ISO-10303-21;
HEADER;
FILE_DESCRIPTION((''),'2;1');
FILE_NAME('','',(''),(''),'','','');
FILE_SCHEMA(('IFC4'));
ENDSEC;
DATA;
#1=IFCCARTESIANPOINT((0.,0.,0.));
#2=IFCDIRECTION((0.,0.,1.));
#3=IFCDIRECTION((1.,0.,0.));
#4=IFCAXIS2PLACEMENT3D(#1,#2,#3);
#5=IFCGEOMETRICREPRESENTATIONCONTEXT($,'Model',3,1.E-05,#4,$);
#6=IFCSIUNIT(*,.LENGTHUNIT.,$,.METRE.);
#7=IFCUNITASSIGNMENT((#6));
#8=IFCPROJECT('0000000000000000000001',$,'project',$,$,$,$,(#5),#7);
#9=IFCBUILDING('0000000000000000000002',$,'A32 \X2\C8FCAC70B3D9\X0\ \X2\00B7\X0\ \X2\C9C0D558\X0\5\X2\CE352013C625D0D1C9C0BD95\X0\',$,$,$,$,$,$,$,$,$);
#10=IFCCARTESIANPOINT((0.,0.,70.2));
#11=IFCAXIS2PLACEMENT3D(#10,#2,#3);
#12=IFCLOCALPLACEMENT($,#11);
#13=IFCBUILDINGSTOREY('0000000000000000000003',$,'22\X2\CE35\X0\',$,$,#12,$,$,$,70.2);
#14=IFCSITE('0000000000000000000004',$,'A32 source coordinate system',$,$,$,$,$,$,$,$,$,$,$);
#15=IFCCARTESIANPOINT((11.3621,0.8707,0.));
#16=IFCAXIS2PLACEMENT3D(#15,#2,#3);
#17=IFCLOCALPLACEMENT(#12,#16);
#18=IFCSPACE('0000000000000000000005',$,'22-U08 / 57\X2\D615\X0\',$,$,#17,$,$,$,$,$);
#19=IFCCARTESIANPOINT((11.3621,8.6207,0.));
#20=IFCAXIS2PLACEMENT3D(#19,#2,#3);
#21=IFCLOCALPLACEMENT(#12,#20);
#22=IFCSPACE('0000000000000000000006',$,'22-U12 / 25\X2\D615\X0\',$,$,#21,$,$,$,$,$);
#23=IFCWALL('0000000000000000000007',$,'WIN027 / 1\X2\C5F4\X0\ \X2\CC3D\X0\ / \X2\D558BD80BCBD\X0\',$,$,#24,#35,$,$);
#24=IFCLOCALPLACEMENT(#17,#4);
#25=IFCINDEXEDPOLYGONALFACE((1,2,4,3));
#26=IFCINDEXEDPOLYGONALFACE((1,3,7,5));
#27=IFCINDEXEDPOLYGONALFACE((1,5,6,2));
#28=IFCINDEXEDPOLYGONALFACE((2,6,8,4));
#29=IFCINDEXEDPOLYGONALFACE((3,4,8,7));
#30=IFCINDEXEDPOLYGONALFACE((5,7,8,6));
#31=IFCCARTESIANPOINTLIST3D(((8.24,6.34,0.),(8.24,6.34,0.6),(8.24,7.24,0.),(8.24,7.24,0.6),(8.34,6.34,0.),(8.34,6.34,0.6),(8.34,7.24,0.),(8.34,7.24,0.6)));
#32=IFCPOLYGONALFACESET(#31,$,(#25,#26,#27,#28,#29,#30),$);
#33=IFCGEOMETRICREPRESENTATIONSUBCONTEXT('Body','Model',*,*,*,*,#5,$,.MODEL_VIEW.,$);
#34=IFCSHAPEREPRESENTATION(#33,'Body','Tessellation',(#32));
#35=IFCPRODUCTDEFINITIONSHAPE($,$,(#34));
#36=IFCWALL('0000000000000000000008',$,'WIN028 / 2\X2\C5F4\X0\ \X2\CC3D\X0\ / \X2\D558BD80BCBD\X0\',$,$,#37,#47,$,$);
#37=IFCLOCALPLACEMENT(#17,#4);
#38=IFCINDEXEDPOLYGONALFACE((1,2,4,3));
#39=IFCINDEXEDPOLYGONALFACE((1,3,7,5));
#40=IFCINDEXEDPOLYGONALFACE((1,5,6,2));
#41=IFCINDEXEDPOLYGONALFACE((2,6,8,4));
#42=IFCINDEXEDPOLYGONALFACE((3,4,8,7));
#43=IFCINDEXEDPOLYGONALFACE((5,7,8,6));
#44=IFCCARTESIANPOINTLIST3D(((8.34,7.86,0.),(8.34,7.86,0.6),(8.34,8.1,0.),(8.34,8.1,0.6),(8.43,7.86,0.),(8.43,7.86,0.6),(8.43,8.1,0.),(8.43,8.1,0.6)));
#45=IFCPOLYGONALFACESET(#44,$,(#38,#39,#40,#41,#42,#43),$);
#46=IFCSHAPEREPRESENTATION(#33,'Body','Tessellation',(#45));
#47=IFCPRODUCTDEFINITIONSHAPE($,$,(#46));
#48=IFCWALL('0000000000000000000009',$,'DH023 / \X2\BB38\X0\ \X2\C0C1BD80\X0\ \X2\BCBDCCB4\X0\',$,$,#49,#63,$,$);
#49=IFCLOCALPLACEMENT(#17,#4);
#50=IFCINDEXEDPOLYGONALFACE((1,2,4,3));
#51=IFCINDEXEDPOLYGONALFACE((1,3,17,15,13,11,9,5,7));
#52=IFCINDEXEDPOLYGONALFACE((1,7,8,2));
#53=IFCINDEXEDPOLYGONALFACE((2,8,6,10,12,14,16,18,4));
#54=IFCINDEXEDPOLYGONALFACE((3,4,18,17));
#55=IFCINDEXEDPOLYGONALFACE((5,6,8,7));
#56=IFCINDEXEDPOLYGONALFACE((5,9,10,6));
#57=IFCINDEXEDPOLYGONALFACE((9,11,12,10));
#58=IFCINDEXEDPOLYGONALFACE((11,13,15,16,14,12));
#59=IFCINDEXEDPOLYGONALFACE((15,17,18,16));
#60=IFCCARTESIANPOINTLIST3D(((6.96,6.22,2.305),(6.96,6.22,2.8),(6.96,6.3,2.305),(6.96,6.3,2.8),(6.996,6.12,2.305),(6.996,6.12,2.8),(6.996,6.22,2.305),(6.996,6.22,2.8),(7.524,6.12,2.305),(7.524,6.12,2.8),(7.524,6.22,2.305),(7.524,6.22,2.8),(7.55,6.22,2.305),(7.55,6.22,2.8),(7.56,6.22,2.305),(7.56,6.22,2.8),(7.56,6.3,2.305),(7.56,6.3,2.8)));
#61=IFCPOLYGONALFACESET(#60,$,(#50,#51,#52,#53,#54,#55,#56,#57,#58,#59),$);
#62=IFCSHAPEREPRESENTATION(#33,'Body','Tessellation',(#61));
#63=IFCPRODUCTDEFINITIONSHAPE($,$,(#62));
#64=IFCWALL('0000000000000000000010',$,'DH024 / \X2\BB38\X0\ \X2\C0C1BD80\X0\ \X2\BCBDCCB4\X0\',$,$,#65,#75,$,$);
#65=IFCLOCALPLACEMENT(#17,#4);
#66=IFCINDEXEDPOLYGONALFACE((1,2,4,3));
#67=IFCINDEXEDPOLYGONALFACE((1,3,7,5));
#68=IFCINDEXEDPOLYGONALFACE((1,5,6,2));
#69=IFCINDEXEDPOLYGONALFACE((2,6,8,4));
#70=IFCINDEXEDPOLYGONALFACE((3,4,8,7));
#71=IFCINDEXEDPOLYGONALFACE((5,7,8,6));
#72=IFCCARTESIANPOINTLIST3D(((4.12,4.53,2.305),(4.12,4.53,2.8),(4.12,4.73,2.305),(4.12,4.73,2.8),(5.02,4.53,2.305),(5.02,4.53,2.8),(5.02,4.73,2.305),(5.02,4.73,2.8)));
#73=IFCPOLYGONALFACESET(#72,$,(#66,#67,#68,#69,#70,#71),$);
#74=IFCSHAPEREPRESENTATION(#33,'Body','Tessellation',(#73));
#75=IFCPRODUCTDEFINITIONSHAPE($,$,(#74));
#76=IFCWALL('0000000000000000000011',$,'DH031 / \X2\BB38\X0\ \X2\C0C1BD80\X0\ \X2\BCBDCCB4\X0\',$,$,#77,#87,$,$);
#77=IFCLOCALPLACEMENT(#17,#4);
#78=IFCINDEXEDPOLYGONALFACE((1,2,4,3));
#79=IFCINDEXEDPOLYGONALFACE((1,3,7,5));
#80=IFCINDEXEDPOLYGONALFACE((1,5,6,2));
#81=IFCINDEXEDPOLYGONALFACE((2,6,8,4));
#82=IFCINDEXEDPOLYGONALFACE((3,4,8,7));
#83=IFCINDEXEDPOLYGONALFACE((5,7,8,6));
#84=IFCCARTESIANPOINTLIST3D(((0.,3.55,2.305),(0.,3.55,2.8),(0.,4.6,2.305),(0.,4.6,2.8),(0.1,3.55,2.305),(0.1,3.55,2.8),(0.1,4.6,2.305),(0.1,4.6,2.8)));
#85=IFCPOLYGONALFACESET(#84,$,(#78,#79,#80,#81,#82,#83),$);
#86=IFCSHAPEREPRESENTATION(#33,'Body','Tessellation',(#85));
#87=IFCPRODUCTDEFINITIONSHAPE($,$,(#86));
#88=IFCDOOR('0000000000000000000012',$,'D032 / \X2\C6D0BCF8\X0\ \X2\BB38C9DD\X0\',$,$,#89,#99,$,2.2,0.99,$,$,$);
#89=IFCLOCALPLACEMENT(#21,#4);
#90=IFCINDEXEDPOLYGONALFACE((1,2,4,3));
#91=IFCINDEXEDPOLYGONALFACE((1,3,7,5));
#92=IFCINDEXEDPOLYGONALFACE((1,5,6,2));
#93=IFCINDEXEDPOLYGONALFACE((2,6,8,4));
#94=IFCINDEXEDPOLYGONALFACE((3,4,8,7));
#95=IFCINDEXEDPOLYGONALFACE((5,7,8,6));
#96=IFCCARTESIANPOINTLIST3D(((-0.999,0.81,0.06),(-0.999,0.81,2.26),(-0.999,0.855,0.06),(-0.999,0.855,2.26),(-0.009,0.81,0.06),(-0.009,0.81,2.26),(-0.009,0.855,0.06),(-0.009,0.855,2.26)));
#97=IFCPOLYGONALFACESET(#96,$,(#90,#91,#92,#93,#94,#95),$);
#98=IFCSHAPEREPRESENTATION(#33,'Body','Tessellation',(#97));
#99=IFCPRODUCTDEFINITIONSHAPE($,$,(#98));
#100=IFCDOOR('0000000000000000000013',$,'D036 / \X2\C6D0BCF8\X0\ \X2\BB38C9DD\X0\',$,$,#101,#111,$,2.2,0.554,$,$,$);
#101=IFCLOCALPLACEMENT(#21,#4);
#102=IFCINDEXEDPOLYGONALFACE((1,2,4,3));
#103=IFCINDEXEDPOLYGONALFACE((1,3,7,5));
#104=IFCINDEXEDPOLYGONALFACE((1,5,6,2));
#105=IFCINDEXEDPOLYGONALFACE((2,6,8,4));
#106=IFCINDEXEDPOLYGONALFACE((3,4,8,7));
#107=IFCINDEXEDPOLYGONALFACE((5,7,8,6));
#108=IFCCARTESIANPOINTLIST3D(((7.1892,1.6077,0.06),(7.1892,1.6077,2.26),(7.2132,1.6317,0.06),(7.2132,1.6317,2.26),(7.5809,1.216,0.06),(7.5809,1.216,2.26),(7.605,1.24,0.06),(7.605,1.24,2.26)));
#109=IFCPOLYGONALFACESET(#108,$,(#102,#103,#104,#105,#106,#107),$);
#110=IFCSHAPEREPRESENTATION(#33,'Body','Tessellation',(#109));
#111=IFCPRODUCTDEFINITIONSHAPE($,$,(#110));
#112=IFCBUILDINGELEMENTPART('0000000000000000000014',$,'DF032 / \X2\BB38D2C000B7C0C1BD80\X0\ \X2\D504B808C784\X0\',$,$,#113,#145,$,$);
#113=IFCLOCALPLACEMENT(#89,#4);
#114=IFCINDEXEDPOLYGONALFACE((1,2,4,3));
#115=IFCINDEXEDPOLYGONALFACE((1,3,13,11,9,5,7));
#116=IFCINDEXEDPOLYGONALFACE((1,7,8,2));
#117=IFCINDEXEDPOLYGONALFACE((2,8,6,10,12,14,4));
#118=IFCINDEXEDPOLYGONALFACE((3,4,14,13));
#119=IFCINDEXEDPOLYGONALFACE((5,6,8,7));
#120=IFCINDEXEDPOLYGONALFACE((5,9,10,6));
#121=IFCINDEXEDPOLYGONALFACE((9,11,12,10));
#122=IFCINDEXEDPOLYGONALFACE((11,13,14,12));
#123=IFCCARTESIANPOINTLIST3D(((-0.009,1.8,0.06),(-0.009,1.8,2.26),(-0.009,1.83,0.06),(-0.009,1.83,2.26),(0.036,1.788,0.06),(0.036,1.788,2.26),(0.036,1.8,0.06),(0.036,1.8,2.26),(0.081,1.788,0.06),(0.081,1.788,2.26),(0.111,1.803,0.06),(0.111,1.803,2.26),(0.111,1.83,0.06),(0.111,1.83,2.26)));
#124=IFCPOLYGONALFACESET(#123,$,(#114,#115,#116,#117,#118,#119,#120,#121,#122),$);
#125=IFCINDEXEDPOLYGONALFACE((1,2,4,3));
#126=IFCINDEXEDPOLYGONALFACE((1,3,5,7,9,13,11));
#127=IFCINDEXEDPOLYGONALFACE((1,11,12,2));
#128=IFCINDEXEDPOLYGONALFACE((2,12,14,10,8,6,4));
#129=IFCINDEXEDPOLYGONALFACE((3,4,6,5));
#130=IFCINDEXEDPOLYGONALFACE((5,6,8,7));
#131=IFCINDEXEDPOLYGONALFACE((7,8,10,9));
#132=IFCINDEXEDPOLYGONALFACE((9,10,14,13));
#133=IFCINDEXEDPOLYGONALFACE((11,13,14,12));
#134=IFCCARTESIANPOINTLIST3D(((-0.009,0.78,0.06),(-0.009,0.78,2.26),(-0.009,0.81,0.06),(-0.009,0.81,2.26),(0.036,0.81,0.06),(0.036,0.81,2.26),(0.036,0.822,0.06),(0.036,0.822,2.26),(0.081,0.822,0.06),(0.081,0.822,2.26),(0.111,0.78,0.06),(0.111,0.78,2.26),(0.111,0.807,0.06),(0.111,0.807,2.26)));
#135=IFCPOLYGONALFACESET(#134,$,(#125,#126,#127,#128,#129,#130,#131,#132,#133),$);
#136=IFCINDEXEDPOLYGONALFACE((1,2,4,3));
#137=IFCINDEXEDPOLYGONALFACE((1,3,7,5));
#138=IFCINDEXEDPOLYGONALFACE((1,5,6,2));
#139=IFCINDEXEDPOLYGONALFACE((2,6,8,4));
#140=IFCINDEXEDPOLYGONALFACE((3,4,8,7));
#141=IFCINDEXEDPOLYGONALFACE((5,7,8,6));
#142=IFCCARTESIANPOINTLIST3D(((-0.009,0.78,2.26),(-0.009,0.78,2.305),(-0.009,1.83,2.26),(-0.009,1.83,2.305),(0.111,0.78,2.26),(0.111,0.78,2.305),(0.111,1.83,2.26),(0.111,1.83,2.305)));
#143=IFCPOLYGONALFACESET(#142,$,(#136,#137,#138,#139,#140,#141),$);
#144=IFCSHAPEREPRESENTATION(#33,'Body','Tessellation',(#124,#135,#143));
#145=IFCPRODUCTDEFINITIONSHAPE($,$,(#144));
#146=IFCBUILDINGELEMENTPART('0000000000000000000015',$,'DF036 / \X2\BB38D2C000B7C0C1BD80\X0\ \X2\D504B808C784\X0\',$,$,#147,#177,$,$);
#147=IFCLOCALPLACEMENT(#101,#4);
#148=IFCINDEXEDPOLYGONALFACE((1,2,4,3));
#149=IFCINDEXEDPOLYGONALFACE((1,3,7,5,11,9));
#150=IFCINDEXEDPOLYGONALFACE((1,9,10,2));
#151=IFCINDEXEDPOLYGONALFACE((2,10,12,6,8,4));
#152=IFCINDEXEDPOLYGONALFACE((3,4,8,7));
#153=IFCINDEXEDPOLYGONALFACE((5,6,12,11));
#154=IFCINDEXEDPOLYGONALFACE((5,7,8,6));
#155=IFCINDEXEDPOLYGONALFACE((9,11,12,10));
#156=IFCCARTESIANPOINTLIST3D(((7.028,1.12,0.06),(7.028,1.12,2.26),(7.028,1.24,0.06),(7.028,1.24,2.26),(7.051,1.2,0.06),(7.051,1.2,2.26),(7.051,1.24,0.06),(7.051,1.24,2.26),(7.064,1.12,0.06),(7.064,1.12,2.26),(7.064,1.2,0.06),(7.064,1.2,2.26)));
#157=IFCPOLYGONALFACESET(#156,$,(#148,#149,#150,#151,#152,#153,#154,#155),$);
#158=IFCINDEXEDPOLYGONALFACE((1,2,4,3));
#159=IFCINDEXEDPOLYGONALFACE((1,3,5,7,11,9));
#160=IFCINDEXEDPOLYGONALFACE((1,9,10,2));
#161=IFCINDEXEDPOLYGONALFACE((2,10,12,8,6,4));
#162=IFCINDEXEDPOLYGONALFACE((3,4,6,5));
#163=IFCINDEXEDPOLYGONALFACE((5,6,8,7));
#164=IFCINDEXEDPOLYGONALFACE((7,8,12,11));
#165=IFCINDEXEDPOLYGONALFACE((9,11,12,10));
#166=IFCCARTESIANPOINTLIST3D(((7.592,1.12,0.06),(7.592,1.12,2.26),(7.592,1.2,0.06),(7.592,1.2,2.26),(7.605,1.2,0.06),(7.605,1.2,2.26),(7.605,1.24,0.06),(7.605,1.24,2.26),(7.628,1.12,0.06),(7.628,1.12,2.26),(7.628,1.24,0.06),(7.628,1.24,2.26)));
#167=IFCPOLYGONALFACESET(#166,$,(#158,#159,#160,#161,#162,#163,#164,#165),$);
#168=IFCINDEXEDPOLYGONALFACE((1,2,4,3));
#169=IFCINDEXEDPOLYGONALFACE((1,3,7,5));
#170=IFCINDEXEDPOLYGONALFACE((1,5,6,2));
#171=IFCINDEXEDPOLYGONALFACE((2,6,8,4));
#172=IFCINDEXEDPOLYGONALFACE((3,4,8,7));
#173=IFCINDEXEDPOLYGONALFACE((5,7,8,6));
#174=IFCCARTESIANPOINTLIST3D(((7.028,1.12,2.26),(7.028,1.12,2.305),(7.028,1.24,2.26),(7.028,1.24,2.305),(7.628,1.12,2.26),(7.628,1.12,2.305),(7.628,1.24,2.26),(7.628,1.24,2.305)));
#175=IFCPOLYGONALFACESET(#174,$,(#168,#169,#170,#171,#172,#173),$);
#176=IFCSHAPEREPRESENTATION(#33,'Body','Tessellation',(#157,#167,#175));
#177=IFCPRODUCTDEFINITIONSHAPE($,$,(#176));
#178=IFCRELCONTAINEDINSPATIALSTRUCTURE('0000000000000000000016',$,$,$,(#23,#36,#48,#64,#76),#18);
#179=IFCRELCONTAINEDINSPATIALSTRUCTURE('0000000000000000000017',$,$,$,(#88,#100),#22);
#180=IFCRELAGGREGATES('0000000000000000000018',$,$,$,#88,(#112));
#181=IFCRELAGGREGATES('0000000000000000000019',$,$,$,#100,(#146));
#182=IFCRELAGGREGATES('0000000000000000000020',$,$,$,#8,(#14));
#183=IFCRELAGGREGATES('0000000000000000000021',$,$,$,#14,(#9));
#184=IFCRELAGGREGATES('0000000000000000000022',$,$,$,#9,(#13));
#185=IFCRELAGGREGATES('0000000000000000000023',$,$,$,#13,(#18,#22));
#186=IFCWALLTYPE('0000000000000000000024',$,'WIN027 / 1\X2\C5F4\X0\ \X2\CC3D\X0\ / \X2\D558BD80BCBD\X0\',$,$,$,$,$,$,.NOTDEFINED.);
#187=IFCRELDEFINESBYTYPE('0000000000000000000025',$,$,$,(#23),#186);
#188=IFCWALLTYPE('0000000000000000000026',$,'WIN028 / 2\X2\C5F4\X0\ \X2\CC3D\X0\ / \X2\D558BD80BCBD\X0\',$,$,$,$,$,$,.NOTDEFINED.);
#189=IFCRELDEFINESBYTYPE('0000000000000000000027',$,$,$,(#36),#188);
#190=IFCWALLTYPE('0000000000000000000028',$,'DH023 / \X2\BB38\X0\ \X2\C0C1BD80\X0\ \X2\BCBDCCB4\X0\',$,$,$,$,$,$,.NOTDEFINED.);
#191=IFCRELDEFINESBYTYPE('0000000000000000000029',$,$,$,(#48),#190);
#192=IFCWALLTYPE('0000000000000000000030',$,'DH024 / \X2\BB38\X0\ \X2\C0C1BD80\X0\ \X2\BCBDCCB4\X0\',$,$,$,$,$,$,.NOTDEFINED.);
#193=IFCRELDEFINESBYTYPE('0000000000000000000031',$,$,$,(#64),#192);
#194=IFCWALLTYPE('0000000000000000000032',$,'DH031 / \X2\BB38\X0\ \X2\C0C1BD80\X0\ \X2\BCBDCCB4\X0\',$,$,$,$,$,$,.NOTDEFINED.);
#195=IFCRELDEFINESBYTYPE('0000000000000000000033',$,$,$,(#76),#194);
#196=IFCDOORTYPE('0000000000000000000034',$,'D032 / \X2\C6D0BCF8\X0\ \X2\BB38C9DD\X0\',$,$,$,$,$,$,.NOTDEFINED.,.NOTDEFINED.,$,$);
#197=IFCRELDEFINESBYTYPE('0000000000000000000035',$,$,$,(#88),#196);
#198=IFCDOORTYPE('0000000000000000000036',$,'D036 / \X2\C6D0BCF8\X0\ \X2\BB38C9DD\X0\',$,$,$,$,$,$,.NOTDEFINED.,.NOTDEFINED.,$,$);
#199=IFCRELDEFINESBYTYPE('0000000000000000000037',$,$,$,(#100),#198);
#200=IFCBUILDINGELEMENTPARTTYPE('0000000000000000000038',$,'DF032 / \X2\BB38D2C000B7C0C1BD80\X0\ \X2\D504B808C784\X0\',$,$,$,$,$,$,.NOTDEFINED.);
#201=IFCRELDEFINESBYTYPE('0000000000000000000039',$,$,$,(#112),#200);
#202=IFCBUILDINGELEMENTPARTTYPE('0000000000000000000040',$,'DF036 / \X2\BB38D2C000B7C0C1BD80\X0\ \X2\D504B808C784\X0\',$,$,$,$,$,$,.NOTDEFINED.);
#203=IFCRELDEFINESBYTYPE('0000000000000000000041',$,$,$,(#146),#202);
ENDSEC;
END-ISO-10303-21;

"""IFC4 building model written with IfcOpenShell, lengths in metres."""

from ifc_helpers import new_model, si_unit, frame, origin, origin_with_axes, place, context, subcontext, project, spatial, polyline, outline, extrude, source, transform, mapped, type_object, type_shapes, element, aggregate, save


model = new_model("IFC4")

# Units and contexts
model_context = context("Model", 3, precision=1e-05, world=origin_with_axes())
body_context = subcontext(model_context, "Body", "Model", "MODEL_VIEW")
ifc_project = project(units=[si_unit("LENGTHUNIT", "METRE")], contexts=[model_context])

# Site, building, storey, space
storey_placement = place(None, frame((0.0, 0.0, 70.2), z_axis=(0.0, 0.0, 1.0), x_axis=(1.0, 0.0, 0.0)))
space_1_placement = place(storey_placement, frame((11.3621, 8.6207, 0.0), z_axis=(0.0, 0.0, 1.0), x_axis=(1.0, 0.0, 0.0)))
site = spatial("IfcSite", under=ifc_project, Name="A32 source coordinate system")
building = spatial("IfcBuilding", under=site, Name="A32 주거동 · 지하5층–옥탑지붕")
storey = spatial("IfcBuildingStorey", under=building, at=storey_placement, Name="22층", Elevation=70.2)
space_2_placement = place(storey_placement, frame((11.3621, 0.8707, 0.0), z_axis=(0.0, 0.0, 1.0), x_axis=(1.0, 0.0, 0.0)))
space_2 = spatial("IfcSpace", under=storey, at=space_2_placement, Name="22-U08 / 57형")

# Walls
wall_type_1 = type_object("IfcWallType", Name="WIN027 / 1열 창 / 하부벽", PredefinedType="NOTDEFINED")
shared_shape_1 = source(origin(), body_context, "Body", "SweptSolid", [
    extrude(outline(polyline([(8.24, 6.34), (8.24, 7.24), (8.34, 7.24), (8.34, 6.34), (8.24, 6.34)])), origin(), (0.0, 0.0, 1.0), 0.6),
])
type_shapes(wall_type_1, [shared_shape_1])
wall_1_placement = place(space_2_placement, origin_with_axes())
element("IfcWall", 1, at=wall_1_placement, inside=space_2, type_object=wall_type_1, Name="WIN027 / 1열 창 / 하부벽", context=body_context, shape_type="MappedRepresentation", body=[
    mapped(shared_shape_1, transform((0.0, 0.0, 0.0), scale=1.0)),
])
wall_type_2 = type_object("IfcWallType", Name="WIN028 / 2열 창 / 하부벽", PredefinedType="NOTDEFINED")
shared_shape_2 = source(origin(), body_context, "Body", "SweptSolid", [
    extrude(outline(polyline([(8.34, 7.86), (8.34, 8.1), (8.43, 8.1), (8.43, 7.86), (8.34, 7.86)])), origin(), (0.0, 0.0, 1.0), 0.6),
])
type_shapes(wall_type_2, [shared_shape_2])
wall_2_placement = place(space_2_placement, origin_with_axes())
element("IfcWall", 2, at=wall_2_placement, inside=space_2, type_object=wall_type_2, Name="WIN028 / 2열 창 / 하부벽", context=body_context, shape_type="MappedRepresentation", body=[
    mapped(shared_shape_2, transform((0.0, 0.0, 0.0), scale=1.0)),
])
wall_type_3 = type_object("IfcWallType", Name="DH023 / 문 상부 벽체", PredefinedType="NOTDEFINED")
shared_shape_3 = source(origin(), body_context, "Body", "SweptSolid", [
    extrude(outline(polyline([(6.96, 6.3), (7.56, 6.3), (7.56, 6.22), (7.55, 6.22), (7.524, 6.22), (7.524, 6.12), (6.996, 6.12), (6.996, 6.22), (6.96, 6.22), (6.96, 6.3)])), frame((0.0, 0.0, 2.305)), (0.0, 0.0, 1.0), 0.495),
])
type_shapes(wall_type_3, [shared_shape_3])
wall_3_placement = place(space_2_placement, origin_with_axes())
element("IfcWall", 3, at=wall_3_placement, inside=space_2, type_object=wall_type_3, Name="DH023 / 문 상부 벽체", context=body_context, shape_type="MappedRepresentation", body=[
    mapped(shared_shape_3, transform((0.0, 0.0, 0.0), scale=1.0)),
])
wall_type_4 = type_object("IfcWallType", Name="DH024 / 문 상부 벽체", PredefinedType="NOTDEFINED")
shared_shape_4 = source(origin(), body_context, "Body", "SweptSolid", [
    extrude(outline(polyline([(4.12, 4.73), (5.02, 4.73), (5.02, 4.53), (4.12, 4.53), (4.12, 4.73)])), frame((0.0, 0.0, 2.305)), (0.0, 0.0, 1.0), 0.495),
])
type_shapes(wall_type_4, [shared_shape_4])
wall_4_placement = place(space_2_placement, origin_with_axes())
element("IfcWall", 4, at=wall_4_placement, inside=space_2, type_object=wall_type_4, Name="DH024 / 문 상부 벽체", context=body_context, shape_type="MappedRepresentation", body=[
    mapped(shared_shape_4, transform((0.0, 0.0, 0.0), scale=1.0)),
])
wall_type_5 = type_object("IfcWallType", Name="DH031 / 문 상부 벽체", PredefinedType="NOTDEFINED")
shared_shape_5 = source(origin(), body_context, "Body", "SweptSolid", [
    extrude(outline(polyline([(0.0, 4.6), (0.1, 4.6), (0.1, 3.55), (0.0, 3.55), (0.0, 4.6)])), frame((0.0, 0.0, 2.305)), (0.0, 0.0, 1.0), 0.495),
])
type_shapes(wall_type_5, [shared_shape_5])
wall_5_placement = place(space_2_placement, origin_with_axes())
element("IfcWall", 5, at=wall_5_placement, inside=space_2, type_object=wall_type_5, Name="DH031 / 문 상부 벽체", context=body_context, shape_type="MappedRepresentation", body=[
    mapped(shared_shape_5, transform((0.0, 0.0, 0.0), scale=1.0)),
])

# Shared definitions
space_1 = spatial("IfcSpace", under=storey, at=space_1_placement, Name="22-U12 / 25형")

# Doors
door_type_1 = type_object("IfcDoorType", Name="D032 / 원본 문짝", OperationType="NOTDEFINED", PredefinedType="NOTDEFINED")
shared_shape_6 = source(origin(), body_context, "Body", "SweptSolid", [
    extrude(outline(polyline([(-0.009, 0.81), (-0.999, 0.81), (-0.999, 0.855), (-0.009, 0.855), (-0.009, 0.81)])), frame((0.0, 0.0, 0.06)), (0.0, 0.0, 1.0), 2.2),
])
type_shapes(door_type_1, [shared_shape_6])
door_1_placement = place(space_1_placement, origin_with_axes())
door_1 = element("IfcDoor", 6, at=door_1_placement, inside=space_1, type_object=door_type_1, Name="D032 / 원본 문짝", OverallHeight=2.2, OverallWidth=0.99, context=body_context, shape_type="MappedRepresentation", body=[
    mapped(shared_shape_6, transform((0.0, 0.0, 0.0), scale=1.0)),
])
door_type_2 = type_object("IfcDoorType", Name="D036 / 원본 문짝", OperationType="NOTDEFINED", PredefinedType="NOTDEFINED")
shared_shape_7 = source(origin(), body_context, "Body", "SweptSolid", [
    extrude(outline(polyline([(7.1892, 1.6077), (7.2132, 1.6317), (7.605, 1.24), (7.5809, 1.216), (7.1892, 1.6077)])), frame((0.0, 0.0, 0.06)), (0.0, 0.0, 1.0), 2.2),
])
type_shapes(door_type_2, [shared_shape_7])
door_2_placement = place(space_1_placement, origin_with_axes())
door_2 = element("IfcDoor", 7, at=door_2_placement, inside=space_1, type_object=door_type_2, Name="D036 / 원본 문짝", OverallHeight=2.2, OverallWidth=0.554, context=body_context, shape_type="MappedRepresentation", body=[
    mapped(shared_shape_7, transform((0.0, 0.0, 0.0), scale=1.0)),
])

# Building element parts
building_element_part_type_1 = type_object("IfcBuildingElementPartType", Name="DF032 / 문틀·상부 프레임", PredefinedType="NOTDEFINED")
shared_shape_8 = source(origin(), body_context, "Body", "SweptSolid", [
    extrude(outline(polyline([(0.111, 1.83), (0.111, 1.803), (0.081, 1.788), (0.036, 1.788), (0.036, 1.8), (-0.009, 1.8), (-0.009, 1.83), (0.111, 1.83)])), frame((0.0, 0.0, 0.06)), (0.0, 0.0, 1.0), 2.2),
    extrude(outline(polyline([(-0.009, 0.81), (0.036, 0.81), (0.036, 0.822), (0.081, 0.822), (0.111, 0.807), (0.111, 0.78), (-0.009, 0.78), (-0.009, 0.81)])), frame((0.0, 0.0, 0.06)), (0.0, 0.0, 1.0), 2.2),
    extrude(outline(polyline([(-0.009, 0.78), (-0.009, 1.83), (0.111, 1.83), (0.111, 0.78), (-0.009, 0.78)])), frame((0.0, 0.0, 2.26)), (0.0, 0.0, 1.0), 0.045),
])
type_shapes(building_element_part_type_1, [shared_shape_8])
building_element_part_1_placement = place(door_1_placement, origin_with_axes())
building_element_part_1 = element("IfcBuildingElementPart", 8, at=building_element_part_1_placement, type_object=building_element_part_type_1, Name="DF032 / 문틀·상부 프레임", context=body_context, shape_type="MappedRepresentation", body=[
    mapped(shared_shape_8, transform((0.0, 0.0, 0.0), scale=1.0)),
])
aggregate(door_1, [building_element_part_1])
building_element_part_type_2 = type_object("IfcBuildingElementPartType", Name="DF036 / 문틀·상부 프레임", PredefinedType="NOTDEFINED")
shared_shape_9 = source(origin(), body_context, "Body", "SweptSolid", [
    extrude(outline(polyline([(7.028, 1.24), (7.051, 1.24), (7.051, 1.2), (7.064, 1.2), (7.064, 1.12), (7.028, 1.12), (7.028, 1.24)])), frame((0.0, 0.0, 0.06)), (0.0, 0.0, 1.0), 2.2),
    extrude(outline(polyline([(7.592, 1.12), (7.592, 1.2), (7.605, 1.2), (7.605, 1.24), (7.628, 1.24), (7.628, 1.12), (7.592, 1.12)])), frame((0.0, 0.0, 0.06)), (0.0, 0.0, 1.0), 2.2),
    extrude(outline(polyline([(7.028, 1.12), (7.028, 1.24), (7.628, 1.24), (7.628, 1.12), (7.028, 1.12)])), frame((0.0, 0.0, 2.26)), (0.0, 0.0, 1.0), 0.045),
])
type_shapes(building_element_part_type_2, [shared_shape_9])
building_element_part_2_placement = place(door_2_placement, origin_with_axes())
building_element_part_2 = element("IfcBuildingElementPart", 9, at=building_element_part_2_placement, type_object=building_element_part_type_2, Name="DF036 / 문틀·상부 프레임", context=body_context, shape_type="MappedRepresentation", body=[
    mapped(shared_shape_9, transform((0.0, 0.0, 0.0), scale=1.0)),
])
aggregate(door_2, [building_element_part_2])

save(model, "model.ifc")
